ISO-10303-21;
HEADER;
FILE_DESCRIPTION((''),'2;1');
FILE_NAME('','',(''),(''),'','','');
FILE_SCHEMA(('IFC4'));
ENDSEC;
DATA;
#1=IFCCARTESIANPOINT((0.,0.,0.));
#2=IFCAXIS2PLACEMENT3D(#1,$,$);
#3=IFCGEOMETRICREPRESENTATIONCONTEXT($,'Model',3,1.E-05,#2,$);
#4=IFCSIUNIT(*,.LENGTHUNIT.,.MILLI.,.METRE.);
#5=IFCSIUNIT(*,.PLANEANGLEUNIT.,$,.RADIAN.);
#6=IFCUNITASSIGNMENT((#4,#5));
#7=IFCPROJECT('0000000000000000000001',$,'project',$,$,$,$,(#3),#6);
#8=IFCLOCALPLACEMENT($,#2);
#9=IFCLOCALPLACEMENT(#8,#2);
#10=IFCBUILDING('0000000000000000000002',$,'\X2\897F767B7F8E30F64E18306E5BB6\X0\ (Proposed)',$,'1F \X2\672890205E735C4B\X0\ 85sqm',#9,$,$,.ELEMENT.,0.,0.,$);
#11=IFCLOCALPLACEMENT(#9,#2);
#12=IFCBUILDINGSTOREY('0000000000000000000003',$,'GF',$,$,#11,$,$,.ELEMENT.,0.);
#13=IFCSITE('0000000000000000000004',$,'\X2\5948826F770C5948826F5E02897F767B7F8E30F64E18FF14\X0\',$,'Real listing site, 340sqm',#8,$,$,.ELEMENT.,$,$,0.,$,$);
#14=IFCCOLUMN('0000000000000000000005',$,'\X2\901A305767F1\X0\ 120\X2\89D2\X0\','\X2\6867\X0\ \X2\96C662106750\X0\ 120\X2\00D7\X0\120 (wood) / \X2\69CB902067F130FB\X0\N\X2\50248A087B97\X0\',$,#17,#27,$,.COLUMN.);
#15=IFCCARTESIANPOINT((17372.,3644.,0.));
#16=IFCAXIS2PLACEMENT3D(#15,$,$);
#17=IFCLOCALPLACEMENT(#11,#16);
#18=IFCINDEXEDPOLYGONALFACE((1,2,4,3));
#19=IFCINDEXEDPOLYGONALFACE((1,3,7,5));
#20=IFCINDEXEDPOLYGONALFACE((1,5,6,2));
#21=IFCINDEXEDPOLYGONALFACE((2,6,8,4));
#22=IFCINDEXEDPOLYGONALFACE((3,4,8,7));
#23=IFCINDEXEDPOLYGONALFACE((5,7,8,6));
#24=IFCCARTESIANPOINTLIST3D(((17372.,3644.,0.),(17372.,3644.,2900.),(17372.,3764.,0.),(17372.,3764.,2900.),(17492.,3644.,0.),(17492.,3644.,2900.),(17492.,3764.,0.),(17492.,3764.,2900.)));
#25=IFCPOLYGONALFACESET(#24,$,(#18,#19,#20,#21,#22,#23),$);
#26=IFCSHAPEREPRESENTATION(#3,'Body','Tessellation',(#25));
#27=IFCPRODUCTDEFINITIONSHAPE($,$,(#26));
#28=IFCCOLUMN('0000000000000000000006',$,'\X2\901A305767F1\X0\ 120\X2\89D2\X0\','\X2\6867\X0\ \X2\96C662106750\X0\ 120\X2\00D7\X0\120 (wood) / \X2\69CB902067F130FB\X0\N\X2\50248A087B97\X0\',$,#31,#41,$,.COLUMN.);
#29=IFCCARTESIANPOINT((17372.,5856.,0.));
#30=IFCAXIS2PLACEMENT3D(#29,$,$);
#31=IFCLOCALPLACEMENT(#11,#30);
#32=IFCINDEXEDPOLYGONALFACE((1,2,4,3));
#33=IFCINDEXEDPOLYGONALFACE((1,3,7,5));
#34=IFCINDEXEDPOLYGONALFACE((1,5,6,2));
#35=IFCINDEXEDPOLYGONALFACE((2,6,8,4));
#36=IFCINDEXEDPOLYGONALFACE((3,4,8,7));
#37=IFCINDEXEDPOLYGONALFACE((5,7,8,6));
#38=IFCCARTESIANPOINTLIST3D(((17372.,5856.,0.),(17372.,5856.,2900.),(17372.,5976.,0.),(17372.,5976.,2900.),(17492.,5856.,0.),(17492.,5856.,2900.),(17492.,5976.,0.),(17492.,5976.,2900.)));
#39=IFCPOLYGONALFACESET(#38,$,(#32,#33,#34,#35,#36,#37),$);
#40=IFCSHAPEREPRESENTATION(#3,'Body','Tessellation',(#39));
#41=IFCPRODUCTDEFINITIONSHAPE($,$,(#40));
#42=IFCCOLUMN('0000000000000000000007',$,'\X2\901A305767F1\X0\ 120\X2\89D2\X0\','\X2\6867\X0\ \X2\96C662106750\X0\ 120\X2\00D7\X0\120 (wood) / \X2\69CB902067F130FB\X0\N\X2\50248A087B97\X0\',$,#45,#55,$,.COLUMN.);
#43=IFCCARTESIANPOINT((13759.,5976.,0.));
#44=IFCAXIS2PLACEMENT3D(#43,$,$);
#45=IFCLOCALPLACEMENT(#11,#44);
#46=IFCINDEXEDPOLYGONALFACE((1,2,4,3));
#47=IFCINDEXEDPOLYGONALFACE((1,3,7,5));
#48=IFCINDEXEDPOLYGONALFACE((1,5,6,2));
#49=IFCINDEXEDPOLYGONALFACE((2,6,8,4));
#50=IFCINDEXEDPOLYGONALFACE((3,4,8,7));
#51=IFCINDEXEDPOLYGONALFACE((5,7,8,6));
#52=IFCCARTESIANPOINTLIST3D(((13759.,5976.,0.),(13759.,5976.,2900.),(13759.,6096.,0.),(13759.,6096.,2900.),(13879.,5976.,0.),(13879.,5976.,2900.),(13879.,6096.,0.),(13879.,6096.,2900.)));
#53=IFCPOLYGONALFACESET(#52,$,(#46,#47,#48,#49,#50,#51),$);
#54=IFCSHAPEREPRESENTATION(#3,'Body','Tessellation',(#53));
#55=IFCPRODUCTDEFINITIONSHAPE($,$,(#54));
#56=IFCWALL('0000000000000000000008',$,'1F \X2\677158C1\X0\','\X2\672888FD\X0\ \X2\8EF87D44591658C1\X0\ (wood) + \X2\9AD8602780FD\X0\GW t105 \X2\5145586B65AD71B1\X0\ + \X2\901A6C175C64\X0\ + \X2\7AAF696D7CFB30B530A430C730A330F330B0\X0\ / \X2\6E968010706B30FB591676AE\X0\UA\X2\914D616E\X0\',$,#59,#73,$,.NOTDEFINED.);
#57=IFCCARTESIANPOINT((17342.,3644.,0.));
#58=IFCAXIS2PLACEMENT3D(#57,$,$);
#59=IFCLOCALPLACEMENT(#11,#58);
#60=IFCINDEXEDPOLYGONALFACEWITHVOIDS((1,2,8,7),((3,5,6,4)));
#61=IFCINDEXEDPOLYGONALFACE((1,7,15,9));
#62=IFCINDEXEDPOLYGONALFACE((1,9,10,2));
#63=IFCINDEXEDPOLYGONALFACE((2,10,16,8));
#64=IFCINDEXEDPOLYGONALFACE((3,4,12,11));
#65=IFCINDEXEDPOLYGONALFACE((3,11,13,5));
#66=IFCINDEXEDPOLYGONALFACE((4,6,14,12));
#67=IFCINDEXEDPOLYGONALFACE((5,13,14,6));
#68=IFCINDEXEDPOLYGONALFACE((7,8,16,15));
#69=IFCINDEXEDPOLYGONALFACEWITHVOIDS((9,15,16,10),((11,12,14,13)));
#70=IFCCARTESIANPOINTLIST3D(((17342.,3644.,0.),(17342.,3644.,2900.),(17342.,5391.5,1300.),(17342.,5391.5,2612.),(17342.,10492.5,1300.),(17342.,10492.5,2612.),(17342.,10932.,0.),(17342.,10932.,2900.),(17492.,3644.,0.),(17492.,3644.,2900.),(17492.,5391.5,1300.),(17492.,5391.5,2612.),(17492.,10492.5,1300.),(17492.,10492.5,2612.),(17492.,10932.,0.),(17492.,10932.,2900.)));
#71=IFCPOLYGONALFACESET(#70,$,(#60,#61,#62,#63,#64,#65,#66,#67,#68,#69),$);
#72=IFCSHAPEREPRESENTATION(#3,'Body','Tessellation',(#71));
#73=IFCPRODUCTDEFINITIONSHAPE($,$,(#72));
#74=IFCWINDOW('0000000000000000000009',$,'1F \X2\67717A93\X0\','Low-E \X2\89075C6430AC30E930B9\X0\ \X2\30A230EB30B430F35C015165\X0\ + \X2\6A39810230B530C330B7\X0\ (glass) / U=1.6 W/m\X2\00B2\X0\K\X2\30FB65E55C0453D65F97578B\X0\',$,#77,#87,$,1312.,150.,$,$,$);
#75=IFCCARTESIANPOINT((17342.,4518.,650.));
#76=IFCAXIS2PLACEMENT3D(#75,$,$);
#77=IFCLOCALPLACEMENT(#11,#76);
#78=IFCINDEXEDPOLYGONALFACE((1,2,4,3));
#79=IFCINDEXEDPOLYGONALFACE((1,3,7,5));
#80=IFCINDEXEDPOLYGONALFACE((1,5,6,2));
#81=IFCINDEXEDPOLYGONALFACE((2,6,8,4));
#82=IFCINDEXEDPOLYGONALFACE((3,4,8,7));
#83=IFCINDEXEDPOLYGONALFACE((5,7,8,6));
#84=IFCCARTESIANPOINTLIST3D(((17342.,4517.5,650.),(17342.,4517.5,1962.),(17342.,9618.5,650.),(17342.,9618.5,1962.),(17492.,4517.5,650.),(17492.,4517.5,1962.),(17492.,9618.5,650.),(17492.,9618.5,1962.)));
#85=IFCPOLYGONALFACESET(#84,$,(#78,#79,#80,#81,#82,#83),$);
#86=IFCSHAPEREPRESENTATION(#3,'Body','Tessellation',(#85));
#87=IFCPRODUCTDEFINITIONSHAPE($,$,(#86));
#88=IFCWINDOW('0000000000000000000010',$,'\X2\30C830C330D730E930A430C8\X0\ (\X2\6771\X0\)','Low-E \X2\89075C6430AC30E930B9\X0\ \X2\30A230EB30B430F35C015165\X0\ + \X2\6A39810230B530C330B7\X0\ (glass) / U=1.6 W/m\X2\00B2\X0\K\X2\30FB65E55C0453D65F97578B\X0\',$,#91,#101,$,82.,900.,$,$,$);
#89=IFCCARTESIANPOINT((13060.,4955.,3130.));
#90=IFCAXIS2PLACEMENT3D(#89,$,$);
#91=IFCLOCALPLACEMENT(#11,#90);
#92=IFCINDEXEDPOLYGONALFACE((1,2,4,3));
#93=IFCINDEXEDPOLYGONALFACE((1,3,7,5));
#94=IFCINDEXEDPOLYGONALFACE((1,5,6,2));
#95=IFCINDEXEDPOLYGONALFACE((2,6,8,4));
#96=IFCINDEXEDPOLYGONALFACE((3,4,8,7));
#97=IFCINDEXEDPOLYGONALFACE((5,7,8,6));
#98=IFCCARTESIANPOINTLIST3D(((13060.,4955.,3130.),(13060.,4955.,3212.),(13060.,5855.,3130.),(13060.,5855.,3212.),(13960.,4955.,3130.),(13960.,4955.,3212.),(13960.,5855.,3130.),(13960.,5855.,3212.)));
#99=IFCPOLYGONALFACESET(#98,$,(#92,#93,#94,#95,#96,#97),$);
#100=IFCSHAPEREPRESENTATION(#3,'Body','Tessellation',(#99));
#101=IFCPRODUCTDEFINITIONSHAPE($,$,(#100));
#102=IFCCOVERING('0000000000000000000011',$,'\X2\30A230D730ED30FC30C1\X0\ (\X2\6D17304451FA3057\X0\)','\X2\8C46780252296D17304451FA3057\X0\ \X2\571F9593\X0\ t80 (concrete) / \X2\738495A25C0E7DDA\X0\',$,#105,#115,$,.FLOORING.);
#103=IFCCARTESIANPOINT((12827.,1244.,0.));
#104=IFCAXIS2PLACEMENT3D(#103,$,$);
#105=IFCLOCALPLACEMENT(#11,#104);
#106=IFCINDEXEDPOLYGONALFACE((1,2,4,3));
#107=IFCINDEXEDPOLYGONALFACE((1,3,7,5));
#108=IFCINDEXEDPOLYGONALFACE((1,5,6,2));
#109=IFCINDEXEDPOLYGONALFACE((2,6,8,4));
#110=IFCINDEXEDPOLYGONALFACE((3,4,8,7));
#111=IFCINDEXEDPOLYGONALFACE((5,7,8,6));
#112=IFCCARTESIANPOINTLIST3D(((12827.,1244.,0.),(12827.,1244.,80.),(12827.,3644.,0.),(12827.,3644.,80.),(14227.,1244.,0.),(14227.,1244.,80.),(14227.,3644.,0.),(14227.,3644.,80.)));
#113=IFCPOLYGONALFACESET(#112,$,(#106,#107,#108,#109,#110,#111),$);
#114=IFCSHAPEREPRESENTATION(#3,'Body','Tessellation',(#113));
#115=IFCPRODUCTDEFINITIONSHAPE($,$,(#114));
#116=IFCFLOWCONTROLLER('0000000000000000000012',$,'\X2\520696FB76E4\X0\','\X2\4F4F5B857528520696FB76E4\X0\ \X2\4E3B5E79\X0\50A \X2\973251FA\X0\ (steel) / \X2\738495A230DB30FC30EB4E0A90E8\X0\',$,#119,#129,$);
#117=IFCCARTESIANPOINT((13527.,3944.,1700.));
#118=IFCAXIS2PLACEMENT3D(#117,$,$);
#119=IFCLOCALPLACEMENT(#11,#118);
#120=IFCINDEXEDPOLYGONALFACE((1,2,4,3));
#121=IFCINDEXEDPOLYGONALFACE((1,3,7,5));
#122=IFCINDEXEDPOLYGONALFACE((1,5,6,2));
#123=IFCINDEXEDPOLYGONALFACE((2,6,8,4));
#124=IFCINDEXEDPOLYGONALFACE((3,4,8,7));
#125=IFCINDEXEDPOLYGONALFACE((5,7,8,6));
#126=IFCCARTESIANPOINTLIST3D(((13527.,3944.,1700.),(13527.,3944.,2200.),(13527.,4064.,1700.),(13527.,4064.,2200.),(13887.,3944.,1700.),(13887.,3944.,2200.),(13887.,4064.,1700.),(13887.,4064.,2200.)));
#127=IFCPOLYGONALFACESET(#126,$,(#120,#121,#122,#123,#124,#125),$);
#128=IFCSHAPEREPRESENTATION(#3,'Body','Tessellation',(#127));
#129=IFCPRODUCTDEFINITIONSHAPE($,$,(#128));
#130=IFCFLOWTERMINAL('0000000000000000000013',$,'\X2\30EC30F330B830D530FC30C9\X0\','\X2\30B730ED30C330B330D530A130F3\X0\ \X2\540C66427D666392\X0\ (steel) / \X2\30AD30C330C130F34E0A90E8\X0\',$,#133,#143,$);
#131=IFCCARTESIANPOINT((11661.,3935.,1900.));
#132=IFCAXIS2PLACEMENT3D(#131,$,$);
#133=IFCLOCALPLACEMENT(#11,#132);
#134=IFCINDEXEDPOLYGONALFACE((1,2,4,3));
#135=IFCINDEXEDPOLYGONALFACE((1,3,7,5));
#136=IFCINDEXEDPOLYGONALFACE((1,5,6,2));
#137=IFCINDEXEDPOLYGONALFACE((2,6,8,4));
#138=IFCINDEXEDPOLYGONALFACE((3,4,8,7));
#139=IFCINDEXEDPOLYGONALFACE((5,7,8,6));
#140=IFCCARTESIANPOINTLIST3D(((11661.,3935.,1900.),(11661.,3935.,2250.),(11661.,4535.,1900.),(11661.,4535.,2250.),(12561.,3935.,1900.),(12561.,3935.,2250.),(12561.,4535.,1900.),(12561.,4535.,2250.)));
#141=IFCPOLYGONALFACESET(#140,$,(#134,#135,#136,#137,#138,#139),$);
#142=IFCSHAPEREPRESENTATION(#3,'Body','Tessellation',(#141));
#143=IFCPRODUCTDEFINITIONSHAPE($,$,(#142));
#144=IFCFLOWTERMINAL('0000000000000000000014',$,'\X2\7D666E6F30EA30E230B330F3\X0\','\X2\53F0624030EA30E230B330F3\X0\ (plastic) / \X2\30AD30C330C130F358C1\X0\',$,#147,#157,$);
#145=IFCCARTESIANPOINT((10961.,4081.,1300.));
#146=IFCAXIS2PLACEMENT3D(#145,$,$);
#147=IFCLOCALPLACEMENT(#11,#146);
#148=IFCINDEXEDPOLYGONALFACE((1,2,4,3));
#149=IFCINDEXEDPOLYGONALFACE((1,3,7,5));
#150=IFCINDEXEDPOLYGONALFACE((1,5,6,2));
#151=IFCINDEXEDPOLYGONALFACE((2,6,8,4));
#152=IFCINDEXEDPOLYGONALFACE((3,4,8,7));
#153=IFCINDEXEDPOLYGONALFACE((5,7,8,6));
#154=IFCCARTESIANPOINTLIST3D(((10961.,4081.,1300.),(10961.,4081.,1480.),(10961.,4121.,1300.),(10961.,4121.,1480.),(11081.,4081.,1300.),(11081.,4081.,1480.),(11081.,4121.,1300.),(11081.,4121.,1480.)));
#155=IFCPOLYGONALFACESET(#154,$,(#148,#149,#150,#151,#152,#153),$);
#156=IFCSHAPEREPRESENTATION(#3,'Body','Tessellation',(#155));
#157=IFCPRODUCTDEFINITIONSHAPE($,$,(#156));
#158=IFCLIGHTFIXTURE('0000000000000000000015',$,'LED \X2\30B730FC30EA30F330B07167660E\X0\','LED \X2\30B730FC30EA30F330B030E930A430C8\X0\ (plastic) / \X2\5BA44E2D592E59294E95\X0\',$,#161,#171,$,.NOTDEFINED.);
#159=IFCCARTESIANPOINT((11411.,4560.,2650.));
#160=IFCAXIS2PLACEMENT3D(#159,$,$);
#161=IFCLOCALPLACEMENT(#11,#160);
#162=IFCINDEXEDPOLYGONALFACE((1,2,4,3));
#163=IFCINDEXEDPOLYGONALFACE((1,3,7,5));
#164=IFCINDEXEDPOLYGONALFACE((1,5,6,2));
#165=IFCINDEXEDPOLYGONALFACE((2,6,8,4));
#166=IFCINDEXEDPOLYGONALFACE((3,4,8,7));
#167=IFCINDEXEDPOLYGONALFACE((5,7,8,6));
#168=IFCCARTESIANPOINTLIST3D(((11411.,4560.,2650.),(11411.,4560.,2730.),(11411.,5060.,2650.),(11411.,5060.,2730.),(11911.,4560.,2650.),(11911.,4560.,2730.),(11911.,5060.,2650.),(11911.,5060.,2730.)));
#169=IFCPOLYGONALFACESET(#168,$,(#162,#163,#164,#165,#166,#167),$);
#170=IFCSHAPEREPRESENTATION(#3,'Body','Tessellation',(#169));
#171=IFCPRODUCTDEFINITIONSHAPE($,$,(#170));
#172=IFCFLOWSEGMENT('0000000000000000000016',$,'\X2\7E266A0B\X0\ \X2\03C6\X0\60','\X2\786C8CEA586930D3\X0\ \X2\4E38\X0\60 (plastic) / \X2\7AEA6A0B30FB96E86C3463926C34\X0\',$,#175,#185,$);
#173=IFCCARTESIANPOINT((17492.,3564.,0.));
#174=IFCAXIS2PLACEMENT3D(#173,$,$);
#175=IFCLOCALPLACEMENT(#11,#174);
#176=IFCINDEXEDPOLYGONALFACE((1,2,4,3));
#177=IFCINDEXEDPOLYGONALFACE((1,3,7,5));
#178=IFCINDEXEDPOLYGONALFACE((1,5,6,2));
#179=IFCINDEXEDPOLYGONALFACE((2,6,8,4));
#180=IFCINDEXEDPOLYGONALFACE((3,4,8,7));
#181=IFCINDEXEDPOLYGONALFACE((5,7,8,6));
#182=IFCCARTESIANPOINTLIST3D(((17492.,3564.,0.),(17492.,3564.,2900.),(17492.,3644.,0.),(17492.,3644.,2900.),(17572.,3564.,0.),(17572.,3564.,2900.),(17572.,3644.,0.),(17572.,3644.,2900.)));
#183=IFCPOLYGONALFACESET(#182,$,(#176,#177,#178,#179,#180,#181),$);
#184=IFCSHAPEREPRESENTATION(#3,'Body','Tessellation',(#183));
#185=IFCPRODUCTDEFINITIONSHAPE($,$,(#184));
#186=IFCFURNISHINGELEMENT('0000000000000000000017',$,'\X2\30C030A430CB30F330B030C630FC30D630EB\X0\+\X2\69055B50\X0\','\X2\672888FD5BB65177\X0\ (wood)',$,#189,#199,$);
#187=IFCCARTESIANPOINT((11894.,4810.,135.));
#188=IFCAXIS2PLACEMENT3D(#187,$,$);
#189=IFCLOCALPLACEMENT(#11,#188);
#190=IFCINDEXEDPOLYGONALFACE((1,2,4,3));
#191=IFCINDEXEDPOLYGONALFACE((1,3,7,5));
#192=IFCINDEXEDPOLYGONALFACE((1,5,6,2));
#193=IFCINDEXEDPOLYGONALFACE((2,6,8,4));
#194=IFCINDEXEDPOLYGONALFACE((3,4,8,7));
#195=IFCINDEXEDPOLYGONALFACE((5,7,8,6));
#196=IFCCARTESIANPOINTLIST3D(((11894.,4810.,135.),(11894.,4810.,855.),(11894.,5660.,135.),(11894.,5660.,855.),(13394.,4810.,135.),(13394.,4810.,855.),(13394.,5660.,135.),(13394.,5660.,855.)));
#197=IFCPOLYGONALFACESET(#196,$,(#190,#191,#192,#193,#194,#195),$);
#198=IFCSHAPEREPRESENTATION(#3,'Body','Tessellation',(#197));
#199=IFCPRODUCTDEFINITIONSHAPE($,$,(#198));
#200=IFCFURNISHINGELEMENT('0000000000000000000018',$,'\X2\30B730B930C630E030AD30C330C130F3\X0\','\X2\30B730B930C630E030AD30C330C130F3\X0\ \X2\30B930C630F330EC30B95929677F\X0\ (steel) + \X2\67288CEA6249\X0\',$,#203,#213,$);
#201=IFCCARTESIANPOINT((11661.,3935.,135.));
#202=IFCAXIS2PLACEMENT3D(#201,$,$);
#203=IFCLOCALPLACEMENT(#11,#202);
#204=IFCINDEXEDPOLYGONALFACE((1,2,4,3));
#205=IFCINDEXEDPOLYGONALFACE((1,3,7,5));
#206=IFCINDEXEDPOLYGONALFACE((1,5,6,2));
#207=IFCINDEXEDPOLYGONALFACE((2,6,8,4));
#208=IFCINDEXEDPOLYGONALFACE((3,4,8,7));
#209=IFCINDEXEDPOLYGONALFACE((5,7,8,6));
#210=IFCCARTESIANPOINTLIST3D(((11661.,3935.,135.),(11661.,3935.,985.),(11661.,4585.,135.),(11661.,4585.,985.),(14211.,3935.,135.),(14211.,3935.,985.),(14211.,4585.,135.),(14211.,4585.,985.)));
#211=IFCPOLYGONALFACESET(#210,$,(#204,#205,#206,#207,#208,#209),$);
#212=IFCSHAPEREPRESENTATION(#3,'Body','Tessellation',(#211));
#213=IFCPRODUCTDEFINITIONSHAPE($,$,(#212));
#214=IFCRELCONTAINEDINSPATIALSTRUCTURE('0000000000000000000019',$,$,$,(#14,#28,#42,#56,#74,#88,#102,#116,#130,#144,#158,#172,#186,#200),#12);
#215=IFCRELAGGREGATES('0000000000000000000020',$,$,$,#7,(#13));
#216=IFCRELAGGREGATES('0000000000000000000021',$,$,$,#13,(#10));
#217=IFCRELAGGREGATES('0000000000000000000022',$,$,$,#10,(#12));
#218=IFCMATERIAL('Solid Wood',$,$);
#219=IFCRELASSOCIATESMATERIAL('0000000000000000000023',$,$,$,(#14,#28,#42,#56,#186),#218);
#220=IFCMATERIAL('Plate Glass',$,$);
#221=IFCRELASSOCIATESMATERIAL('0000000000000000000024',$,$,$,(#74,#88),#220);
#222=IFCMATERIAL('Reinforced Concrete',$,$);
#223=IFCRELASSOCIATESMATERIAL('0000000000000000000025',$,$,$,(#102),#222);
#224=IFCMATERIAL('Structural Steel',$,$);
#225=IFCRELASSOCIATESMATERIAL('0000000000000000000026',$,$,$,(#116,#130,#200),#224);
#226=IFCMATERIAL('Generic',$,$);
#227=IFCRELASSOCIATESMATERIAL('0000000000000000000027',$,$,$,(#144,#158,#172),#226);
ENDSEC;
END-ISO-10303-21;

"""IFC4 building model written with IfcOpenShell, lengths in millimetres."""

from ifc_helpers import new_model, si_unit, frame, frame_2d, origin, place, context, project, spatial, rectangle, extrude, material, element, fill, save


model = new_model("IFC4")

# Units and contexts
model_context = context("Model", 3, precision=1e-05, world=origin())
ifc_project = project(units=[si_unit("LENGTHUNIT", "METRE", prefix="MILLI"), si_unit("PLANEANGLEUNIT", "RADIAN")], contexts=[model_context])

# Site, building, storey
site_placement = place(None, origin())
site = spatial("IfcSite", under=ifc_project, at=site_placement, Name="奈良県奈良市西登美ヶ丘４", ObjectType="Real listing site, 340sqm", CompositionType="ELEMENT", RefElevation=0.0)
building_placement = place(site_placement, origin())
building = spatial("IfcBuilding", under=site, at=building_placement, Name="西登美ヶ丘の家 (Proposed)", ObjectType="1F 木造平屋 85sqm", CompositionType="ELEMENT", ElevationOfRefHeight=0.0, ElevationOfTerrain=0.0)
storey_placement = place(building_placement, origin())
storey = spatial("IfcBuildingStorey", under=building, at=storey_placement, Name="GF", CompositionType="ELEMENT", Elevation=0.0)

# Columns
ifc_material_1 = material(Name="Solid Wood")
column_1_placement = place(storey_placement, frame((17372.0, 3644.0, 0.0)))
element("IfcColumn", 1, at=column_1_placement, inside=storey, material=ifc_material_1, Name="通し柱 120角", Description="桧 集成材 120×120 (wood) / 構造柱・N値計算", PredefinedType="COLUMN", context=model_context, shape_type="SweptSolid", body=[
    extrude(rectangle(XDim=120.0, YDim=120.0, at=frame_2d((60.0, 60.0))), frame((17372.0, 3644.0, 0.0)), (0.0, 0.0, 1.0), 2900.0),
])
column_2_placement = place(storey_placement, frame((17372.0, 5856.0, 0.0)))
element("IfcColumn", 2, at=column_2_placement, inside=storey, material=ifc_material_1, Name="通し柱 120角", Description="桧 集成材 120×120 (wood) / 構造柱・N値計算", PredefinedType="COLUMN", context=model_context, shape_type="SweptSolid", body=[
    extrude(rectangle(XDim=120.0, YDim=120.0, at=frame_2d((60.0, 60.0))), frame((17372.0, 5856.0, 0.0)), (0.0, 0.0, 1.0), 2900.0),
])
column_3_placement = place(storey_placement, frame((13759.0, 5976.0, 0.0)))
element("IfcColumn", 3, at=column_3_placement, inside=storey, material=ifc_material_1, Name="通し柱 120角", Description="桧 集成材 120×120 (wood) / 構造柱・N値計算", PredefinedType="COLUMN", context=model_context, shape_type="SweptSolid", body=[
    extrude(rectangle(XDim=120.0, YDim=120.0, at=frame_2d((60.0, 60.0))), frame((13759.0, 5976.0, 0.0)), (0.0, 0.0, 1.0), 2900.0),
])

# Wall, opening, window
wall_1_placement = place(storey_placement, frame((17342.0, 3644.0, 0.0)))
wall_1 = element("IfcWall", 4, at=wall_1_placement, inside=storey, material=ifc_material_1, Name="1F 東壁", Description="木製 軸組外壁 (wood) + 高性能GW t105 充填断熱 + 通気層 + 窯業系サイディング / 準耐火・外皮UA配慮", PredefinedType="NOTDEFINED", context=model_context, shape_type="SweptSolid", body=[
    extrude(rectangle(XDim=150.0, YDim=7288.0, at=frame_2d((75.0, 3644.0))), frame((17342.0, 3644.0, 0.0)), (0.0, 0.0, 1.0), 2900.0),
])
opening_1_placement = place(storey_placement, frame((17342.0, 4518.0, 650.0)))
opening_1 = element("IfcOpeningElement", 5, at=opening_1_placement, cuts=wall_1, PredefinedType="NOTDEFINED", context=model_context, shape_type="SweptSolid", body=[
    extrude(rectangle(XDim=150.0, YDim=5101.0, at=frame_2d((75.0, 2550.0))), frame((17342.0, 4518.0, 650.0)), (0.0, 0.0, 1.0), 1312.0),
])
ifc_material_2 = material(Name="Plate Glass")
window_1_placement = place(storey_placement, frame((17342.0, 4518.0, 650.0)))
window_1 = element("IfcWindow", 6, at=window_1_placement, inside=storey, material=ifc_material_2, Name="1F 東窓", Description="Low-E 複層ガラス アルゴン封入 + 樹脂サッシ (glass) / U=1.6 W/m²K・日射取得型", OverallHeight=1312.0, OverallWidth=150.0, context=model_context, shape_type="SweptSolid", body=[
    extrude(rectangle(XDim=150.0, YDim=5101.0, at=frame_2d((75.0, 2550.0))), frame((17342.0, 4518.0, 650.0)), (0.0, 0.0, 1.0), 1312.0),
])
fill(opening_1, window_1)

# Window
window_2_placement = place(storey_placement, frame((13060.0, 4955.0, 3130.0)))
element("IfcWindow", 7, at=window_2_placement, inside=storey, material=ifc_material_2, Name="トップライト (東)", Description="Low-E 複層ガラス アルゴン封入 + 樹脂サッシ (glass) / U=1.6 W/m²K・日射取得型", OverallHeight=82.0, OverallWidth=900.0, context=model_context, shape_type="SweptSolid", body=[
    extrude(rectangle(XDim=900.0, YDim=900.0, at=frame_2d((450.0, 450.0))), frame((13060.0, 4955.0, 3130.0)), (0.0, 0.0, 1.0), 82.0),
])

# Shared definitions
ifc_material_3 = material(Name="Structural Steel")

# Covering
ifc_material_4 = material(Name="Reinforced Concrete")
covering_placement = place(storey_placement, frame((12827.0, 1244.0, 0.0)))
element("IfcCovering", 8, at=covering_placement, inside=storey, material=ifc_material_4, Name="アプローチ (洗い出し)", Description="豆砂利洗い出し 土間 t80 (concrete) / 玄関導線", PredefinedType="FLOORING", context=model_context, shape_type="SweptSolid", body=[
    extrude(rectangle(XDim=1400.0, YDim=2400.0, at=frame_2d((700.0, 1200.0))), frame((12827.0, 1244.0, 0.0)), (0.0, 0.0, 1.0), 80.0),
])

# Flow controller
flow_controller_placement = place(storey_placement, frame((13527.0, 3944.0, 1700.0)))
element("IfcFlowController", 9, at=flow_controller_placement, inside=storey, material=ifc_material_3, Name="分電盤", Description="住宅用分電盤 主幹50A 露出 (steel) / 玄関ホール上部", context=model_context, shape_type="SweptSolid", body=[
    extrude(rectangle(XDim=360.0, YDim=120.0, at=frame_2d((180.0, 60.0))), frame((13527.0, 3944.0, 1700.0)), (0.0, 0.0, 1.0), 500.0),
])

# Flow terminals
flow_terminal_1_placement = place(storey_placement, frame((11661.0, 3935.0, 1900.0)))
element("IfcFlowTerminal", 10, at=flow_terminal_1_placement, inside=storey, material=ifc_material_3, Name="レンジフード", Description="シロッコファン 同時給排 (steel) / キッチン上部", context=model_context, shape_type="SweptSolid", body=[
    extrude(rectangle(XDim=900.0, YDim=600.0, at=frame_2d((450.0, 300.0))), frame((11661.0, 3935.0, 1900.0)), (0.0, 0.0, 1.0), 350.0),
])
ifc_material_5 = material(Name="Generic")
flow_terminal_2_placement = place(storey_placement, frame((10961.0, 4081.0, 1300.0)))
element("IfcFlowTerminal", 11, at=flow_terminal_2_placement, inside=storey, material=ifc_material_5, Name="給湯リモコン", Description="台所リモコン (plastic) / キッチン壁", context=model_context, shape_type="SweptSolid", body=[
    extrude(rectangle(XDim=120.0, YDim=40.0, at=frame_2d((60.0, 20.0))), frame((10961.0, 4081.0, 1300.0)), (0.0, 0.0, 1.0), 180.0),
])

# Light fixture
light_fixture_placement = place(storey_placement, frame((11411.0, 4560.0, 2650.0)))
element("IfcLightFixture", 12, at=light_fixture_placement, inside=storey, material=ifc_material_5, Name="LED シーリング照明", Description="LED シーリングライト (plastic) / 室中央天井", PredefinedType="NOTDEFINED", context=model_context, shape_type="SweptSolid", body=[
    extrude(rectangle(XDim=500.0, YDim=500.0, at=frame_2d((250.0, 250.0))), frame((11411.0, 4560.0, 2650.0)), (0.0, 0.0, 1.0), 80.0),
])

# Flow segment
flow_segment_placement = place(storey_placement, frame((17492.0, 3564.0, 0.0)))
element("IfcFlowSegment", 13, at=flow_segment_placement, inside=storey, material=ifc_material_5, Name="縦樋 φ60", Description="硬質塩ビ 丸60 (plastic) / 竪樋・雨水排水", context=model_context, shape_type="SweptSolid", body=[
    extrude(rectangle(XDim=80.0, YDim=80.0, at=frame_2d((40.0, 40.0))), frame((17492.0, 3564.0, 0.0)), (0.0, 0.0, 1.0), 2900.0),
])

# Furnishing elements
furnishing_1_placement = place(storey_placement, frame((11894.0, 4810.0, 135.0)))
element("IfcFurnishingElement", 14, at=furnishing_1_placement, inside=storey, material=ifc_material_1, Name="ダイニングテーブル+椅子", Description="木製家具 (wood)", context=model_context, shape_type="SweptSolid", body=[
    extrude(rectangle(XDim=1500.0, YDim=850.0, at=frame_2d((750.0, 425.0))), frame((11894.0, 4810.0, 135.0)), (0.0, 0.0, 1.0), 720.0),
])
furnishing_2_placement = place(storey_placement, frame((11661.0, 3935.0, 135.0)))
element("IfcFurnishingElement", 15, at=furnishing_2_placement, inside=storey, material=ifc_material_3, Name="システムキッチン", Description="システムキッチン ステンレス天板 (steel) + 木質扉", context=model_context, shape_type="SweptSolid", body=[
    extrude(rectangle(XDim=2550.0, YDim=650.0, at=frame_2d((1275.0, 325.0))), frame((11661.0, 3935.0, 135.0)), (0.0, 0.0, 1.0), 850.0),
])

save(model, "model.ifc")
